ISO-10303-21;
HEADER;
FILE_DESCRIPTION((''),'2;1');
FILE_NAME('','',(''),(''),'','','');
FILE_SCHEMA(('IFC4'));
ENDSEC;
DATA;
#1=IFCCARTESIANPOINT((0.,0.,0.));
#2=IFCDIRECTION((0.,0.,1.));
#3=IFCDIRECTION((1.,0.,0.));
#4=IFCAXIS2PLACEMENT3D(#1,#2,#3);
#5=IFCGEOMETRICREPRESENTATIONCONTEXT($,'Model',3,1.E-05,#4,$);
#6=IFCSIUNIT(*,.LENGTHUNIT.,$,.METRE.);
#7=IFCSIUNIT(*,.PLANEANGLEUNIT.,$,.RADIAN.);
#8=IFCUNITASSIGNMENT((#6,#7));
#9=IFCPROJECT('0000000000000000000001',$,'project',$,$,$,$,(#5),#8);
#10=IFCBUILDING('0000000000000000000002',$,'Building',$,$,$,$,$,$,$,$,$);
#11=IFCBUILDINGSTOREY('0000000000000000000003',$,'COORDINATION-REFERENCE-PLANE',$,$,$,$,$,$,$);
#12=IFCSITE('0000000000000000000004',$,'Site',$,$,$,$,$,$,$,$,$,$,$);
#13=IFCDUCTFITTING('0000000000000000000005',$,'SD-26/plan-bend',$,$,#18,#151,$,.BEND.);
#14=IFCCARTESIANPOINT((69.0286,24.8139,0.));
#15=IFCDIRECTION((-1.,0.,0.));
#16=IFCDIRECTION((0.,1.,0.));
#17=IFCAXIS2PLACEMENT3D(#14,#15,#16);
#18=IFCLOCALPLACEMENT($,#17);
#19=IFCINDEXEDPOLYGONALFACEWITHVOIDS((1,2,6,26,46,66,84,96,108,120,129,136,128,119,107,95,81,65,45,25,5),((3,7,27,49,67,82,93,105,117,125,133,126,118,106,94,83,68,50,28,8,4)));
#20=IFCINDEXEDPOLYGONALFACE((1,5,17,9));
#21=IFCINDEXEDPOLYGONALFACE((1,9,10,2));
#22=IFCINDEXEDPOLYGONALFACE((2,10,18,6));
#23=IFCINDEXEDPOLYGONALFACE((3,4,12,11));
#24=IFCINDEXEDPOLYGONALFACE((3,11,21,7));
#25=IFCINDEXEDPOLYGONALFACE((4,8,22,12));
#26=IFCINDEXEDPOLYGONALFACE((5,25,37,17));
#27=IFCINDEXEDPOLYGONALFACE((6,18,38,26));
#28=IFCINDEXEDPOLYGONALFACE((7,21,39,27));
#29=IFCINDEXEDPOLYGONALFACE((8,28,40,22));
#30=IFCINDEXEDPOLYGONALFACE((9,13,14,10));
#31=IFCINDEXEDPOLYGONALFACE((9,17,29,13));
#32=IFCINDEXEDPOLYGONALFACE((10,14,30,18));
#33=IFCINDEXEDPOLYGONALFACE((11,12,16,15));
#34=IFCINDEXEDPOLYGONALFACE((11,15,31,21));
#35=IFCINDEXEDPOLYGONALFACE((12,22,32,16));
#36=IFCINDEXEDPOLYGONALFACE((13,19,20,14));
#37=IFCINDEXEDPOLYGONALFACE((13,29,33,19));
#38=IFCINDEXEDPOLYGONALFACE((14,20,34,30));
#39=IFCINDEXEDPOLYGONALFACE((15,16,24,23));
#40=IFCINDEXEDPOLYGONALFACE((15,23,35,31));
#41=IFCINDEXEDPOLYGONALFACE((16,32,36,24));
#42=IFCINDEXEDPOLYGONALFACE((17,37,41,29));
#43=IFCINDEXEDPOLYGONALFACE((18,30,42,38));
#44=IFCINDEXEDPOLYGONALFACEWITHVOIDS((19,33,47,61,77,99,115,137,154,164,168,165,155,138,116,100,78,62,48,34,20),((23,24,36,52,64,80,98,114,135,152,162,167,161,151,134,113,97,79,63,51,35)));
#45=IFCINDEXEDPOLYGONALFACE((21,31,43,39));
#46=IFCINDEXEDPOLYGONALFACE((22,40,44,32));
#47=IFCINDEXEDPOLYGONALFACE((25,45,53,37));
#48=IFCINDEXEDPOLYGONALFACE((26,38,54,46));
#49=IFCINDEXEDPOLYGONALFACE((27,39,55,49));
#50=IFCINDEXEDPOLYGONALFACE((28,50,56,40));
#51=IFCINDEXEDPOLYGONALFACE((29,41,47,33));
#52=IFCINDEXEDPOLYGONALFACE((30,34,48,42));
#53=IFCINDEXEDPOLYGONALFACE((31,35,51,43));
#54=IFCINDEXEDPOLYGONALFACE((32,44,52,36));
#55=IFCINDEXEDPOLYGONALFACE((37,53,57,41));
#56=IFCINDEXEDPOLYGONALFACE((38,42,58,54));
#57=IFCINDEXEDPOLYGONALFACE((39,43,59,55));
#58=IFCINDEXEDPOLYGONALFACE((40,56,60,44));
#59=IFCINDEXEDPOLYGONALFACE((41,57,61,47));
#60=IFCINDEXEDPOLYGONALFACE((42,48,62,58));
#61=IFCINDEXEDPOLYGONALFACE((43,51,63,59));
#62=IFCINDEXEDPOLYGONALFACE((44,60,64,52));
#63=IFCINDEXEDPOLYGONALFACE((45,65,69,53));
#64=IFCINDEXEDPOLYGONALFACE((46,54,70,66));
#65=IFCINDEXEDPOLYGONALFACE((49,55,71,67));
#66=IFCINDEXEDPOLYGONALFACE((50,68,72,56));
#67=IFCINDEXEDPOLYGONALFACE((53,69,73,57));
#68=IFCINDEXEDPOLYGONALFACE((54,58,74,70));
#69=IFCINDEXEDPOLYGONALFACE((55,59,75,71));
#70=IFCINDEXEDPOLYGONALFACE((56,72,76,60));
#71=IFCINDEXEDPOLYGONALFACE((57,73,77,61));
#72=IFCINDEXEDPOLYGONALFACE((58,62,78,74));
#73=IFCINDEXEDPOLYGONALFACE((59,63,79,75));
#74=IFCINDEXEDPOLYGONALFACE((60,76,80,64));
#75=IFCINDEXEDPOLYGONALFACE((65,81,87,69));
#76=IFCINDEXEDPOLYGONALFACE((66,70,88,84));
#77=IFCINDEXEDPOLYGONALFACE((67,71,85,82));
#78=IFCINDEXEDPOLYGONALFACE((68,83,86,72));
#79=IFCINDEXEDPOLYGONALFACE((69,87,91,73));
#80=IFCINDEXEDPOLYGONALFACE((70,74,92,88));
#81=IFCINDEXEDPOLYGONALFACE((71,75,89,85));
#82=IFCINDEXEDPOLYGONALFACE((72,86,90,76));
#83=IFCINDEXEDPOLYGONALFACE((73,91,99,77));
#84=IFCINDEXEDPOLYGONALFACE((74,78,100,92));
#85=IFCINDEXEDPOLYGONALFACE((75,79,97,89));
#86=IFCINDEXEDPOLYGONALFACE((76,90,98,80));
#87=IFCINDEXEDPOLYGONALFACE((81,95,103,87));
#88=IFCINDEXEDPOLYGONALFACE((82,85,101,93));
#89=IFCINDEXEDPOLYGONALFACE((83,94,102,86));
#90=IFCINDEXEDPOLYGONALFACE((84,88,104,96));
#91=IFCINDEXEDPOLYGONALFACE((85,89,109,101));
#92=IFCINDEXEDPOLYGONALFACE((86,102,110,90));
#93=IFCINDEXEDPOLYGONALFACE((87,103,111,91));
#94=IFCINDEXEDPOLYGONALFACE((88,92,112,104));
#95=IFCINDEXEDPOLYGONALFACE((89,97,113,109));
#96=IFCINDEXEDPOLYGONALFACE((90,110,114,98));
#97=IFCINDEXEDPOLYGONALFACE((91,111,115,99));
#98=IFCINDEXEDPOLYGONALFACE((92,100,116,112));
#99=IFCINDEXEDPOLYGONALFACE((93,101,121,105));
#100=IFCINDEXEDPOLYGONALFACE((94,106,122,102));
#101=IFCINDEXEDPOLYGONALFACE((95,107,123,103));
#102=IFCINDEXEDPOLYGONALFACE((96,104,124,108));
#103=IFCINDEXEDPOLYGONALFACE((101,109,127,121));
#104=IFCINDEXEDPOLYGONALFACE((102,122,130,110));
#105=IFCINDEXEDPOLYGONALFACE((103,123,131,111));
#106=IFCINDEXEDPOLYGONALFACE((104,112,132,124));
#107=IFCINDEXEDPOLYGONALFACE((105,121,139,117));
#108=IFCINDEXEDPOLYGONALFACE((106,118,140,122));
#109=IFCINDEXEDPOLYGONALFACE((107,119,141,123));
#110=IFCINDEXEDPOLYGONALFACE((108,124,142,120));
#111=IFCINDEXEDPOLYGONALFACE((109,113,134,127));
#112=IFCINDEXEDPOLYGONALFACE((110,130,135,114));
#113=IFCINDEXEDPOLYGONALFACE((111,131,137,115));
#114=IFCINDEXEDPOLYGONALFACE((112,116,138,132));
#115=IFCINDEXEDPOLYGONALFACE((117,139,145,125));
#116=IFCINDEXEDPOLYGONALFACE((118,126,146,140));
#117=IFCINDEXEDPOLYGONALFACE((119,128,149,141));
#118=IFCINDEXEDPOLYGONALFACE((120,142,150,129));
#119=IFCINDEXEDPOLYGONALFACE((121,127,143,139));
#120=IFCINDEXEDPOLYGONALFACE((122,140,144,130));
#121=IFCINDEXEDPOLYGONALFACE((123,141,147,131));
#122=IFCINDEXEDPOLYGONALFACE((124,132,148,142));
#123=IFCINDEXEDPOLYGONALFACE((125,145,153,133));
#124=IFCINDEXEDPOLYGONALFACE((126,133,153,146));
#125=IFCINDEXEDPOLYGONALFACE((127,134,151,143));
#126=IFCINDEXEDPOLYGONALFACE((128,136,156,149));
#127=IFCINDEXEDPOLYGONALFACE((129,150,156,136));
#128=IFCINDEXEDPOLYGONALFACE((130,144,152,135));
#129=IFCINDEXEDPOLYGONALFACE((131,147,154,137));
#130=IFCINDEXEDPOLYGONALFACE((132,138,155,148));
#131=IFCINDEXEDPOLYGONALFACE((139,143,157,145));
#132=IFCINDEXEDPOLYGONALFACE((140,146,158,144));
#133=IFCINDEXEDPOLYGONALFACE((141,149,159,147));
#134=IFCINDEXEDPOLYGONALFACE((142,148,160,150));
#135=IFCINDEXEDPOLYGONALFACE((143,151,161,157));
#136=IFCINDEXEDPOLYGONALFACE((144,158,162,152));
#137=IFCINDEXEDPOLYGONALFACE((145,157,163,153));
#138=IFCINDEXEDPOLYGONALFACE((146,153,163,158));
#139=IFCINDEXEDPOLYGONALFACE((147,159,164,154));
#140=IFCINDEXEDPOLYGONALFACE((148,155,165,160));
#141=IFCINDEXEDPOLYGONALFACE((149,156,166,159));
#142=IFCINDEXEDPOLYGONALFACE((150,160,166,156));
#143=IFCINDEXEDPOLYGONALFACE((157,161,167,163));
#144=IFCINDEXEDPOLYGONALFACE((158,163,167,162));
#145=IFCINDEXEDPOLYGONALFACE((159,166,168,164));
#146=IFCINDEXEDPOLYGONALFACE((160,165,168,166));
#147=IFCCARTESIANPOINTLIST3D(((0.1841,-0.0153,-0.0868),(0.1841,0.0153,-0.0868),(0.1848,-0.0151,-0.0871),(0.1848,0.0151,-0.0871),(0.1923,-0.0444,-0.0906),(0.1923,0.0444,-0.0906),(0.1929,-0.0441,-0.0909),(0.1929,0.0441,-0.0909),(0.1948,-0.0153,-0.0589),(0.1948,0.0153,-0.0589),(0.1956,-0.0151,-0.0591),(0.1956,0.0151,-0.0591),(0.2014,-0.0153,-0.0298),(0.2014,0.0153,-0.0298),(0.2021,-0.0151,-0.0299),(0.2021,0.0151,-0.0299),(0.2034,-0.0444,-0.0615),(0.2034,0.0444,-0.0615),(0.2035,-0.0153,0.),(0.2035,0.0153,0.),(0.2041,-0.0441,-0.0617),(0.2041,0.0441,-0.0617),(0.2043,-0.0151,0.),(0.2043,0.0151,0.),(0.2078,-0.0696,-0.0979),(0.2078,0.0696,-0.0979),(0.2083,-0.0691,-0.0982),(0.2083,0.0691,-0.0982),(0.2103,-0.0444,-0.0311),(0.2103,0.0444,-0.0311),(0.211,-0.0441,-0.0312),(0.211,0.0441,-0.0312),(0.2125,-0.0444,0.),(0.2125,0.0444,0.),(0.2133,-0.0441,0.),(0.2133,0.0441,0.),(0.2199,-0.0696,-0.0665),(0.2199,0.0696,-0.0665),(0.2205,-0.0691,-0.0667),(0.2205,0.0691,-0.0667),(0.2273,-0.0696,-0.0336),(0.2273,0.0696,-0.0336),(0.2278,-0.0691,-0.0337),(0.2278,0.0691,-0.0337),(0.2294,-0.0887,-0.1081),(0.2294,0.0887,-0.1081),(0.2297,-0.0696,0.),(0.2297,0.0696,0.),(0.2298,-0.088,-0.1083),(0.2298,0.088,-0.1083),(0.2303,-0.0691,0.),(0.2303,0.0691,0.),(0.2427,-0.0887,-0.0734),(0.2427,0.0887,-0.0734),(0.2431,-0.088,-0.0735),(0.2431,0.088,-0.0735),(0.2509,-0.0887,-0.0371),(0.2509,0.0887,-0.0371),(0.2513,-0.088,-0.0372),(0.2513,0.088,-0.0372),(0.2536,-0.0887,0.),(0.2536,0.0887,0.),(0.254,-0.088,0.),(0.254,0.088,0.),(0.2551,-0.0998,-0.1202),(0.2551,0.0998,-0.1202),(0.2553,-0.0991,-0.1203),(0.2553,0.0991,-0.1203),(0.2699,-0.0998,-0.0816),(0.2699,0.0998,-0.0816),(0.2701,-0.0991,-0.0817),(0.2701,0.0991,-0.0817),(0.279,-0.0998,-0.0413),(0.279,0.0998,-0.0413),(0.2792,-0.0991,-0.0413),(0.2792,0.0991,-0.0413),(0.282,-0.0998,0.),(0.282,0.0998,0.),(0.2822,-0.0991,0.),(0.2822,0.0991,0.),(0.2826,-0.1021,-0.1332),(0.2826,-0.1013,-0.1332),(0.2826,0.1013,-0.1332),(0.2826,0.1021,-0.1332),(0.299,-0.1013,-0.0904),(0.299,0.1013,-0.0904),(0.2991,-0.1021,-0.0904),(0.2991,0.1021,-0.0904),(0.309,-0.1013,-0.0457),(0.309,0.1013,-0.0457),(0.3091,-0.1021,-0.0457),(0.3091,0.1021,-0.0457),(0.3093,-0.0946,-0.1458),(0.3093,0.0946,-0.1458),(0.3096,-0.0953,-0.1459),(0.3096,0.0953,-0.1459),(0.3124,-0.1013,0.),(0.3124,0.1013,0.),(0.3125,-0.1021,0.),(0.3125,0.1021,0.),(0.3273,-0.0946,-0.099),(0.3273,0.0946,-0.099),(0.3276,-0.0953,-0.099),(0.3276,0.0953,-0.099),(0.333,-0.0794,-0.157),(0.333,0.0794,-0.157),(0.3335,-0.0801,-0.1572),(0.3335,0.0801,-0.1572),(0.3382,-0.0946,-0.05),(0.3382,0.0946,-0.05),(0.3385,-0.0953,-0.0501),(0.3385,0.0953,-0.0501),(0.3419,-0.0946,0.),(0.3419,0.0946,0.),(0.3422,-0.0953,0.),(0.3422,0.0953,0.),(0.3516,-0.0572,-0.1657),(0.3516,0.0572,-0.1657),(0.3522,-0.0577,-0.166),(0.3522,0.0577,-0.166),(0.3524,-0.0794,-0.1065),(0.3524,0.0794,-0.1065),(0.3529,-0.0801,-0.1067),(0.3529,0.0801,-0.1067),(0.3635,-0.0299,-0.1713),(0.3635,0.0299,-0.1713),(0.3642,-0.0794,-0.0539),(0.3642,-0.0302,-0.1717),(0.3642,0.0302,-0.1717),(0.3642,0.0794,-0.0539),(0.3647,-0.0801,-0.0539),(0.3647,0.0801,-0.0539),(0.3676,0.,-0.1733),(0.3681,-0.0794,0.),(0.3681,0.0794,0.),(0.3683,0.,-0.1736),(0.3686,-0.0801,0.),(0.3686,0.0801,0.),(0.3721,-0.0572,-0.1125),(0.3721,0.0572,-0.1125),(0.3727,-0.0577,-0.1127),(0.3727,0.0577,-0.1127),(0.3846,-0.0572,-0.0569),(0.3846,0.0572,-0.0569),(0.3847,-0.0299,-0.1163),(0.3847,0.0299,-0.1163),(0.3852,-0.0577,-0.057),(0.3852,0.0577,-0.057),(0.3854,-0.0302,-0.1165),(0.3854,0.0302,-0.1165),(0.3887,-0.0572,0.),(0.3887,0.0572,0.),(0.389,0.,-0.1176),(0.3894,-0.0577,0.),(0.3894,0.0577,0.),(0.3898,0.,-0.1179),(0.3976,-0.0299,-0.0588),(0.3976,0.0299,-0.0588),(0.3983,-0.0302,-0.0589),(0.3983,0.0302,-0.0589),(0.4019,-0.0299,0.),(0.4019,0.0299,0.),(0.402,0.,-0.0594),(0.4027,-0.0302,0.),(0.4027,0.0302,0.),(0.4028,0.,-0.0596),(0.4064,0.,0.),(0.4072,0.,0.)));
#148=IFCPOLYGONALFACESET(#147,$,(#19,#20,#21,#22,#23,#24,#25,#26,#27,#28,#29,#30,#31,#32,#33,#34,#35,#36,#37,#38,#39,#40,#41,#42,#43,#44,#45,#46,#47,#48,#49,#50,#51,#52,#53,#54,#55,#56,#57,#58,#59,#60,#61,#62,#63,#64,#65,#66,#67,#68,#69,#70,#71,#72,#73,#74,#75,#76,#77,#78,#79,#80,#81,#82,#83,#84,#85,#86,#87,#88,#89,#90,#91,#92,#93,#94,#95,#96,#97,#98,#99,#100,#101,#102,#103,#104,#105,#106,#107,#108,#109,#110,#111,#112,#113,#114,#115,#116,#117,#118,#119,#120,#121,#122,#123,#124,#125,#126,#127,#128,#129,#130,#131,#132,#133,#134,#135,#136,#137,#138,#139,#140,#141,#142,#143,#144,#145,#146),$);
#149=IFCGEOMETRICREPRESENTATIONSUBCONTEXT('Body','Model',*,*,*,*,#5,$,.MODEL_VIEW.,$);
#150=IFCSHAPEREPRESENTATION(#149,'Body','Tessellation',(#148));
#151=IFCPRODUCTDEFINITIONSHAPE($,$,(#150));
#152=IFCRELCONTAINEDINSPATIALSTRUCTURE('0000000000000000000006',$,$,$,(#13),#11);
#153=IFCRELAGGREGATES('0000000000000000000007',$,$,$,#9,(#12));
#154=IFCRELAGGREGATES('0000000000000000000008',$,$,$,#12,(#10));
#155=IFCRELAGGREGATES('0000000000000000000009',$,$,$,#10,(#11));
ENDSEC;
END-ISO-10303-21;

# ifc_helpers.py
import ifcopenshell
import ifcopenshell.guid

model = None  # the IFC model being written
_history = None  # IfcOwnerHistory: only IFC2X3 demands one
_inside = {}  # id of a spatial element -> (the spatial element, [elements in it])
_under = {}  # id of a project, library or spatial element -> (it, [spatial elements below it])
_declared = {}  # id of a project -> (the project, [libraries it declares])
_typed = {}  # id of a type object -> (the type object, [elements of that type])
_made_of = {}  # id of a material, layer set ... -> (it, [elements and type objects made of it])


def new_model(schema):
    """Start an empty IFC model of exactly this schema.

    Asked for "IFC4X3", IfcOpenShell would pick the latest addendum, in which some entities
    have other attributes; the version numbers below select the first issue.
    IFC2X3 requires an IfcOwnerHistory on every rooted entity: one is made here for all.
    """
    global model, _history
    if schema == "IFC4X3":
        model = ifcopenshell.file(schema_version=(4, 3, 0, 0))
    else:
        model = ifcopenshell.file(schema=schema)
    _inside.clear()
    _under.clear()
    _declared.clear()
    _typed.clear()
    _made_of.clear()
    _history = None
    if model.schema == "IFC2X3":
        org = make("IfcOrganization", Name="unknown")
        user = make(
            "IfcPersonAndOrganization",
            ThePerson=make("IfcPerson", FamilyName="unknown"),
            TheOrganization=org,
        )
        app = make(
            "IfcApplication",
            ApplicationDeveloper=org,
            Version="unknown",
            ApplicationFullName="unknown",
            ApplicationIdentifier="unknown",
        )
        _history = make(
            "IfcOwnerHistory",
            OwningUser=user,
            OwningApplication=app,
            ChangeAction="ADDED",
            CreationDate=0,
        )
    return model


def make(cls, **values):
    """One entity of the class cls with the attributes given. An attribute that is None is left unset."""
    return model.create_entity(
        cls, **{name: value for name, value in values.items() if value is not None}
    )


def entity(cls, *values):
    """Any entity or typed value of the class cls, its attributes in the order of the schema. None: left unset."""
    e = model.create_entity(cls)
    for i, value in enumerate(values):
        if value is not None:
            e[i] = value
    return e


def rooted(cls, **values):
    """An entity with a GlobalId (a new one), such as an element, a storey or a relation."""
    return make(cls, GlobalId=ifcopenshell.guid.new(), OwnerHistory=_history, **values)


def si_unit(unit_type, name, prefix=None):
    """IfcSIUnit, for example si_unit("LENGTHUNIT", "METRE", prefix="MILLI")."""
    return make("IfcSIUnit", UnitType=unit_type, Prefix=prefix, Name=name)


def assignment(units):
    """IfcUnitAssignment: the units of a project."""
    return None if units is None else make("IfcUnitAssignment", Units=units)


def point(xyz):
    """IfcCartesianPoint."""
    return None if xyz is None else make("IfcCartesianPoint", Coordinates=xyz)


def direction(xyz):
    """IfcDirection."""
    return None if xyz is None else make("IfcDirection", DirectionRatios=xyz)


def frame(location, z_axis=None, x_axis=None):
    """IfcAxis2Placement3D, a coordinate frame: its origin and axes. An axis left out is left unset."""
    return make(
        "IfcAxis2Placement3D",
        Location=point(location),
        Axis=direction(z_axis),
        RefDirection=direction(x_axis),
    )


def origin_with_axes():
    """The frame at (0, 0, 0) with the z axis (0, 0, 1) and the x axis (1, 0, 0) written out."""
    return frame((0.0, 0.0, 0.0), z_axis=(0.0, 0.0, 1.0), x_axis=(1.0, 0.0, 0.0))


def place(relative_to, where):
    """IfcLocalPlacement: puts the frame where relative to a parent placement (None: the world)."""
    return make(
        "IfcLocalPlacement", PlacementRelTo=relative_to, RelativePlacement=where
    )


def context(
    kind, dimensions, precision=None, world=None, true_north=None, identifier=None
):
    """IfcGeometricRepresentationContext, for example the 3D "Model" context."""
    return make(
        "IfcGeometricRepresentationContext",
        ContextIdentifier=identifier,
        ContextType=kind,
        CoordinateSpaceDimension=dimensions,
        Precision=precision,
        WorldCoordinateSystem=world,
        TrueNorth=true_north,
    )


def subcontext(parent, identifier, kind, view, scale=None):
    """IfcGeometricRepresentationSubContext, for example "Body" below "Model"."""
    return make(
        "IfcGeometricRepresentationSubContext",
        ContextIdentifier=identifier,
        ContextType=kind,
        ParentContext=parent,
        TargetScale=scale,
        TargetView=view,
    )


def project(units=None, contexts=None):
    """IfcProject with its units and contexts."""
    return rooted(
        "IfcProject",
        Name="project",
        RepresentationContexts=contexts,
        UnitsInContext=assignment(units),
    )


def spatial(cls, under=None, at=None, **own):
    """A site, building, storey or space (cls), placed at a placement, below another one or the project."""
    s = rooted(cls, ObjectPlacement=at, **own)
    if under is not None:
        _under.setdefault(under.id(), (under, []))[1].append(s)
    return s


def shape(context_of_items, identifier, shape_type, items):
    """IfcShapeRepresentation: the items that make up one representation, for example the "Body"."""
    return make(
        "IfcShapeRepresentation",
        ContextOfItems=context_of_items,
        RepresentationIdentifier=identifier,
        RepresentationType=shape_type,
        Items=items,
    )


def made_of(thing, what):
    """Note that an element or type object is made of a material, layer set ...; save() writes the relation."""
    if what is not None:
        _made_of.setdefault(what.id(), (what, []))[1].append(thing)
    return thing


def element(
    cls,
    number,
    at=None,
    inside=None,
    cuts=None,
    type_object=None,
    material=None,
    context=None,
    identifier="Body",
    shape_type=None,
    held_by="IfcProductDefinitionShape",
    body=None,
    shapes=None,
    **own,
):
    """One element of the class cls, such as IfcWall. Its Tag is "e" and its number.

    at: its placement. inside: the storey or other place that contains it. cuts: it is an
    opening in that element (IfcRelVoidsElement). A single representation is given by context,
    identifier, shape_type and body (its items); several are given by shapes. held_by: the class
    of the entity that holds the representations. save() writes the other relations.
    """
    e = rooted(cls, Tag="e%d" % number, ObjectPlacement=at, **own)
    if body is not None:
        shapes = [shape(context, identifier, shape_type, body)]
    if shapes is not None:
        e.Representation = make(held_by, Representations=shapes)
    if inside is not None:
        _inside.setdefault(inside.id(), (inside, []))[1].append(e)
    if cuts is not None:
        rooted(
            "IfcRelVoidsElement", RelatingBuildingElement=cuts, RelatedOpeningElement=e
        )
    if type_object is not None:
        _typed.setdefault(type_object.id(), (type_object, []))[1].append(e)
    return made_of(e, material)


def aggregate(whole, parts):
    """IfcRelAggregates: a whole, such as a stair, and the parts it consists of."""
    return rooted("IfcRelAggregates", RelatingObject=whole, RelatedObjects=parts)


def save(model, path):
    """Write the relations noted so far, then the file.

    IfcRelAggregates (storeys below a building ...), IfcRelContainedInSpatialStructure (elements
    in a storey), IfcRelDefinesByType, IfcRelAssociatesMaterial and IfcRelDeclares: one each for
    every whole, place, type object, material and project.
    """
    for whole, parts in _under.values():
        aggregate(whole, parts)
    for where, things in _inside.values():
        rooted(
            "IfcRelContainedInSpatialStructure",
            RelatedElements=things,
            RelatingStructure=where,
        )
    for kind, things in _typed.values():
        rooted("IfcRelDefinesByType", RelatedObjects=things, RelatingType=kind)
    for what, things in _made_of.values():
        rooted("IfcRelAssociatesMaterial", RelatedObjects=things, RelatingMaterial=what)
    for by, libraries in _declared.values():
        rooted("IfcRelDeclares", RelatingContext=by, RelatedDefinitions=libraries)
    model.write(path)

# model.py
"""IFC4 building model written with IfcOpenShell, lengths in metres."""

from ifc_helpers import new_model, entity, si_unit, frame, origin_with_axes, place, context, subcontext, project, spatial, element, save


model = new_model("IFC4")

# Units and contexts
model_context_1 = context("Model", 3, precision=1e-05, world=origin_with_axes())
body_context_1 = subcontext(model_context_1, "Body", "Model", "MODEL_VIEW")
ifc_project = project(units=[si_unit("LENGTHUNIT", "METRE"), si_unit("PLANEANGLEUNIT", "RADIAN")], contexts=[model_context_1])

# Site, building, storey
site = spatial("IfcSite", under=ifc_project, Name="Site")
building = spatial("IfcBuilding", under=site, Name="Building")
storey = spatial("IfcBuildingStorey", under=building, Name="COORDINATION-REFERENCE-PLANE")

# Duct fitting
duct_fitting_1_placement = place(None, frame((69.0286, 24.8139, 0.0), z_axis=(-1.0, 0.0, 0.0), x_axis=(0.0, 1.0, 0.0)))
element("IfcDuctFitting", 1, at=duct_fitting_1_placement, inside=storey, Name="SD-26/plan-bend", PredefinedType="BEND", context=body_context_1, shape_type="SweptSolid", body=[
    entity("IfcRevolvedAreaSolid", entity("IfcCircleHollowProfileDef", "AREA", None, entity("IfcAxis2Placement2D", entity("IfcCartesianPoint", [0.3048, 0.0])), 0.1024, 0.0008), entity("IfcAxis2Placement3D", entity("IfcCartesianPoint", [0.0, 0.0, 0.0]), entity("IfcDirection", [0.0, 0.0, 1.0]), entity("IfcDirection", [1.0, 0.0, 0.0])), entity("IfcAxis1Placement", entity("IfcCartesianPoint", [0.0, 0.0, 0.0]), entity("IfcDirection", [0.0, 1.0, 0.0])), 0.440428),
])

save(model, "model.ifc")
